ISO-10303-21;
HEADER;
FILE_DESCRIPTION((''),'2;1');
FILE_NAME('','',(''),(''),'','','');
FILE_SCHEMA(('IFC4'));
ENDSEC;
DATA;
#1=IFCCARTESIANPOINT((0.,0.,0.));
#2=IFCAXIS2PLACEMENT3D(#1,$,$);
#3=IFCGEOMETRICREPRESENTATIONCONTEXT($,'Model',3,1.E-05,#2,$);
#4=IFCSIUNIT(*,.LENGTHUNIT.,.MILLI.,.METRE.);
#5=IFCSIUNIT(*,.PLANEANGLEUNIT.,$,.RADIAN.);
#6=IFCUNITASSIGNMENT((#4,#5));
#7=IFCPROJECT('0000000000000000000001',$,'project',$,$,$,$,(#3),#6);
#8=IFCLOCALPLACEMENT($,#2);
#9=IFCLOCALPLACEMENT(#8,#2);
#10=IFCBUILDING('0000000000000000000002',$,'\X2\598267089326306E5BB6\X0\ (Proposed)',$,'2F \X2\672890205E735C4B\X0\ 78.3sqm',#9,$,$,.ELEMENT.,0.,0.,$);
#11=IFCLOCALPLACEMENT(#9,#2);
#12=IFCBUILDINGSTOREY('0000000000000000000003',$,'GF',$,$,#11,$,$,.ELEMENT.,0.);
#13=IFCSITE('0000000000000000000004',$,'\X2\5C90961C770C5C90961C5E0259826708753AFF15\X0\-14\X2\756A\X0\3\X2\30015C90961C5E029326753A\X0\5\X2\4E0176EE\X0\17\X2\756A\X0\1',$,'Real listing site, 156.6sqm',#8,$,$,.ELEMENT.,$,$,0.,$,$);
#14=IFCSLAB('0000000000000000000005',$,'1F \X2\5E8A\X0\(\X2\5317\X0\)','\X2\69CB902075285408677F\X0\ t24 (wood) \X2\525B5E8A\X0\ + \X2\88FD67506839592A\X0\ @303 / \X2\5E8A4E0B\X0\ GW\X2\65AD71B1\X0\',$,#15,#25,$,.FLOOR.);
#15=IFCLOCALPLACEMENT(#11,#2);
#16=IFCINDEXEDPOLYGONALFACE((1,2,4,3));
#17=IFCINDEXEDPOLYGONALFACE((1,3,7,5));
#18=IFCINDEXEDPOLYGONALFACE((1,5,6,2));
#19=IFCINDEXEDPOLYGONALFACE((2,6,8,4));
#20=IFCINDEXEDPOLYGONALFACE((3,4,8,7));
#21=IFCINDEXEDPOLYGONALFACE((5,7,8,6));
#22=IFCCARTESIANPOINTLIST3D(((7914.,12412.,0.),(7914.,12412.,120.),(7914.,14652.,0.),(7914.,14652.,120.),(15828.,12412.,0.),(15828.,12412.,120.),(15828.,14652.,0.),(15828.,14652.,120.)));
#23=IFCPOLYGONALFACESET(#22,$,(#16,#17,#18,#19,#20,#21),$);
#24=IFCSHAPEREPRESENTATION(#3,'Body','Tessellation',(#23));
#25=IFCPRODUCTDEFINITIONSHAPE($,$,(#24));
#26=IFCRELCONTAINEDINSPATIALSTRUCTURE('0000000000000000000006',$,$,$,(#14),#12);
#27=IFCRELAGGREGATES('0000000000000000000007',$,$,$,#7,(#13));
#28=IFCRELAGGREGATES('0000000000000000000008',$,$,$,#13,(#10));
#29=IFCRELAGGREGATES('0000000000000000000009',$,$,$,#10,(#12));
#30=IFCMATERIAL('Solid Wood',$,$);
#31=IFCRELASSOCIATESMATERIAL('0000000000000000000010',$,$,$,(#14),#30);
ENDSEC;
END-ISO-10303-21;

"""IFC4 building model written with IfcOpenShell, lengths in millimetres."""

from ifc_helpers import new_model, si_unit, frame, frame_2d, origin, place, context, project, spatial, rectangle, extrude, material, element, save


model = new_model("IFC4")

# Units and contexts
model_context = context("Model", 3, precision=1e-05, world=origin())
ifc_project = project(units=[si_unit("LENGTHUNIT", "METRE", prefix="MILLI"), si_unit("PLANEANGLEUNIT", "RADIAN")], contexts=[model_context])

# Site, building, storey
site_placement = place(None, origin())
site = spatial("IfcSite", under=ifc_project, at=site_placement, Name="岐阜県岐阜市如月町５-14番3、岐阜市錦町5丁目17番1", ObjectType="Real listing site, 156.6sqm", CompositionType="ELEMENT", RefElevation=0.0)
building_placement = place(site_placement, origin())
building = spatial("IfcBuilding", under=site, at=building_placement, Name="如月錦の家 (Proposed)", ObjectType="2F 木造平屋 78.3sqm", CompositionType="ELEMENT", ElevationOfRefHeight=0.0, ElevationOfTerrain=0.0)
storey_placement = place(building_placement, origin())
storey = spatial("IfcBuildingStorey", under=building, at=storey_placement, Name="GF", CompositionType="ELEMENT", Elevation=0.0)

# Slab
ifc_material_1 = material(Name="Solid Wood")
slab_1_placement = place(storey_placement, frame((3957.0, 6206.0, 0.0)))
element("IfcSlab", 1, at=slab_1_placement, inside=storey, material=ifc_material_1, Name="1F 床(北)", Description="構造用合板 t24 (wood) 剛床 + 製材根太 @303 / 床下 GW断熱", PredefinedType="FLOOR", context=model_context, shape_type="SweptSolid", body=[
    extrude(rectangle(XDim=7914.0, YDim=2240.0, at=frame_2d((3957.0, 1120.0))), frame((3957.0, 6206.0, 0.0)), (0.0, 0.0, 1.0), 120.0),
])

save(model, "model.ifc")
